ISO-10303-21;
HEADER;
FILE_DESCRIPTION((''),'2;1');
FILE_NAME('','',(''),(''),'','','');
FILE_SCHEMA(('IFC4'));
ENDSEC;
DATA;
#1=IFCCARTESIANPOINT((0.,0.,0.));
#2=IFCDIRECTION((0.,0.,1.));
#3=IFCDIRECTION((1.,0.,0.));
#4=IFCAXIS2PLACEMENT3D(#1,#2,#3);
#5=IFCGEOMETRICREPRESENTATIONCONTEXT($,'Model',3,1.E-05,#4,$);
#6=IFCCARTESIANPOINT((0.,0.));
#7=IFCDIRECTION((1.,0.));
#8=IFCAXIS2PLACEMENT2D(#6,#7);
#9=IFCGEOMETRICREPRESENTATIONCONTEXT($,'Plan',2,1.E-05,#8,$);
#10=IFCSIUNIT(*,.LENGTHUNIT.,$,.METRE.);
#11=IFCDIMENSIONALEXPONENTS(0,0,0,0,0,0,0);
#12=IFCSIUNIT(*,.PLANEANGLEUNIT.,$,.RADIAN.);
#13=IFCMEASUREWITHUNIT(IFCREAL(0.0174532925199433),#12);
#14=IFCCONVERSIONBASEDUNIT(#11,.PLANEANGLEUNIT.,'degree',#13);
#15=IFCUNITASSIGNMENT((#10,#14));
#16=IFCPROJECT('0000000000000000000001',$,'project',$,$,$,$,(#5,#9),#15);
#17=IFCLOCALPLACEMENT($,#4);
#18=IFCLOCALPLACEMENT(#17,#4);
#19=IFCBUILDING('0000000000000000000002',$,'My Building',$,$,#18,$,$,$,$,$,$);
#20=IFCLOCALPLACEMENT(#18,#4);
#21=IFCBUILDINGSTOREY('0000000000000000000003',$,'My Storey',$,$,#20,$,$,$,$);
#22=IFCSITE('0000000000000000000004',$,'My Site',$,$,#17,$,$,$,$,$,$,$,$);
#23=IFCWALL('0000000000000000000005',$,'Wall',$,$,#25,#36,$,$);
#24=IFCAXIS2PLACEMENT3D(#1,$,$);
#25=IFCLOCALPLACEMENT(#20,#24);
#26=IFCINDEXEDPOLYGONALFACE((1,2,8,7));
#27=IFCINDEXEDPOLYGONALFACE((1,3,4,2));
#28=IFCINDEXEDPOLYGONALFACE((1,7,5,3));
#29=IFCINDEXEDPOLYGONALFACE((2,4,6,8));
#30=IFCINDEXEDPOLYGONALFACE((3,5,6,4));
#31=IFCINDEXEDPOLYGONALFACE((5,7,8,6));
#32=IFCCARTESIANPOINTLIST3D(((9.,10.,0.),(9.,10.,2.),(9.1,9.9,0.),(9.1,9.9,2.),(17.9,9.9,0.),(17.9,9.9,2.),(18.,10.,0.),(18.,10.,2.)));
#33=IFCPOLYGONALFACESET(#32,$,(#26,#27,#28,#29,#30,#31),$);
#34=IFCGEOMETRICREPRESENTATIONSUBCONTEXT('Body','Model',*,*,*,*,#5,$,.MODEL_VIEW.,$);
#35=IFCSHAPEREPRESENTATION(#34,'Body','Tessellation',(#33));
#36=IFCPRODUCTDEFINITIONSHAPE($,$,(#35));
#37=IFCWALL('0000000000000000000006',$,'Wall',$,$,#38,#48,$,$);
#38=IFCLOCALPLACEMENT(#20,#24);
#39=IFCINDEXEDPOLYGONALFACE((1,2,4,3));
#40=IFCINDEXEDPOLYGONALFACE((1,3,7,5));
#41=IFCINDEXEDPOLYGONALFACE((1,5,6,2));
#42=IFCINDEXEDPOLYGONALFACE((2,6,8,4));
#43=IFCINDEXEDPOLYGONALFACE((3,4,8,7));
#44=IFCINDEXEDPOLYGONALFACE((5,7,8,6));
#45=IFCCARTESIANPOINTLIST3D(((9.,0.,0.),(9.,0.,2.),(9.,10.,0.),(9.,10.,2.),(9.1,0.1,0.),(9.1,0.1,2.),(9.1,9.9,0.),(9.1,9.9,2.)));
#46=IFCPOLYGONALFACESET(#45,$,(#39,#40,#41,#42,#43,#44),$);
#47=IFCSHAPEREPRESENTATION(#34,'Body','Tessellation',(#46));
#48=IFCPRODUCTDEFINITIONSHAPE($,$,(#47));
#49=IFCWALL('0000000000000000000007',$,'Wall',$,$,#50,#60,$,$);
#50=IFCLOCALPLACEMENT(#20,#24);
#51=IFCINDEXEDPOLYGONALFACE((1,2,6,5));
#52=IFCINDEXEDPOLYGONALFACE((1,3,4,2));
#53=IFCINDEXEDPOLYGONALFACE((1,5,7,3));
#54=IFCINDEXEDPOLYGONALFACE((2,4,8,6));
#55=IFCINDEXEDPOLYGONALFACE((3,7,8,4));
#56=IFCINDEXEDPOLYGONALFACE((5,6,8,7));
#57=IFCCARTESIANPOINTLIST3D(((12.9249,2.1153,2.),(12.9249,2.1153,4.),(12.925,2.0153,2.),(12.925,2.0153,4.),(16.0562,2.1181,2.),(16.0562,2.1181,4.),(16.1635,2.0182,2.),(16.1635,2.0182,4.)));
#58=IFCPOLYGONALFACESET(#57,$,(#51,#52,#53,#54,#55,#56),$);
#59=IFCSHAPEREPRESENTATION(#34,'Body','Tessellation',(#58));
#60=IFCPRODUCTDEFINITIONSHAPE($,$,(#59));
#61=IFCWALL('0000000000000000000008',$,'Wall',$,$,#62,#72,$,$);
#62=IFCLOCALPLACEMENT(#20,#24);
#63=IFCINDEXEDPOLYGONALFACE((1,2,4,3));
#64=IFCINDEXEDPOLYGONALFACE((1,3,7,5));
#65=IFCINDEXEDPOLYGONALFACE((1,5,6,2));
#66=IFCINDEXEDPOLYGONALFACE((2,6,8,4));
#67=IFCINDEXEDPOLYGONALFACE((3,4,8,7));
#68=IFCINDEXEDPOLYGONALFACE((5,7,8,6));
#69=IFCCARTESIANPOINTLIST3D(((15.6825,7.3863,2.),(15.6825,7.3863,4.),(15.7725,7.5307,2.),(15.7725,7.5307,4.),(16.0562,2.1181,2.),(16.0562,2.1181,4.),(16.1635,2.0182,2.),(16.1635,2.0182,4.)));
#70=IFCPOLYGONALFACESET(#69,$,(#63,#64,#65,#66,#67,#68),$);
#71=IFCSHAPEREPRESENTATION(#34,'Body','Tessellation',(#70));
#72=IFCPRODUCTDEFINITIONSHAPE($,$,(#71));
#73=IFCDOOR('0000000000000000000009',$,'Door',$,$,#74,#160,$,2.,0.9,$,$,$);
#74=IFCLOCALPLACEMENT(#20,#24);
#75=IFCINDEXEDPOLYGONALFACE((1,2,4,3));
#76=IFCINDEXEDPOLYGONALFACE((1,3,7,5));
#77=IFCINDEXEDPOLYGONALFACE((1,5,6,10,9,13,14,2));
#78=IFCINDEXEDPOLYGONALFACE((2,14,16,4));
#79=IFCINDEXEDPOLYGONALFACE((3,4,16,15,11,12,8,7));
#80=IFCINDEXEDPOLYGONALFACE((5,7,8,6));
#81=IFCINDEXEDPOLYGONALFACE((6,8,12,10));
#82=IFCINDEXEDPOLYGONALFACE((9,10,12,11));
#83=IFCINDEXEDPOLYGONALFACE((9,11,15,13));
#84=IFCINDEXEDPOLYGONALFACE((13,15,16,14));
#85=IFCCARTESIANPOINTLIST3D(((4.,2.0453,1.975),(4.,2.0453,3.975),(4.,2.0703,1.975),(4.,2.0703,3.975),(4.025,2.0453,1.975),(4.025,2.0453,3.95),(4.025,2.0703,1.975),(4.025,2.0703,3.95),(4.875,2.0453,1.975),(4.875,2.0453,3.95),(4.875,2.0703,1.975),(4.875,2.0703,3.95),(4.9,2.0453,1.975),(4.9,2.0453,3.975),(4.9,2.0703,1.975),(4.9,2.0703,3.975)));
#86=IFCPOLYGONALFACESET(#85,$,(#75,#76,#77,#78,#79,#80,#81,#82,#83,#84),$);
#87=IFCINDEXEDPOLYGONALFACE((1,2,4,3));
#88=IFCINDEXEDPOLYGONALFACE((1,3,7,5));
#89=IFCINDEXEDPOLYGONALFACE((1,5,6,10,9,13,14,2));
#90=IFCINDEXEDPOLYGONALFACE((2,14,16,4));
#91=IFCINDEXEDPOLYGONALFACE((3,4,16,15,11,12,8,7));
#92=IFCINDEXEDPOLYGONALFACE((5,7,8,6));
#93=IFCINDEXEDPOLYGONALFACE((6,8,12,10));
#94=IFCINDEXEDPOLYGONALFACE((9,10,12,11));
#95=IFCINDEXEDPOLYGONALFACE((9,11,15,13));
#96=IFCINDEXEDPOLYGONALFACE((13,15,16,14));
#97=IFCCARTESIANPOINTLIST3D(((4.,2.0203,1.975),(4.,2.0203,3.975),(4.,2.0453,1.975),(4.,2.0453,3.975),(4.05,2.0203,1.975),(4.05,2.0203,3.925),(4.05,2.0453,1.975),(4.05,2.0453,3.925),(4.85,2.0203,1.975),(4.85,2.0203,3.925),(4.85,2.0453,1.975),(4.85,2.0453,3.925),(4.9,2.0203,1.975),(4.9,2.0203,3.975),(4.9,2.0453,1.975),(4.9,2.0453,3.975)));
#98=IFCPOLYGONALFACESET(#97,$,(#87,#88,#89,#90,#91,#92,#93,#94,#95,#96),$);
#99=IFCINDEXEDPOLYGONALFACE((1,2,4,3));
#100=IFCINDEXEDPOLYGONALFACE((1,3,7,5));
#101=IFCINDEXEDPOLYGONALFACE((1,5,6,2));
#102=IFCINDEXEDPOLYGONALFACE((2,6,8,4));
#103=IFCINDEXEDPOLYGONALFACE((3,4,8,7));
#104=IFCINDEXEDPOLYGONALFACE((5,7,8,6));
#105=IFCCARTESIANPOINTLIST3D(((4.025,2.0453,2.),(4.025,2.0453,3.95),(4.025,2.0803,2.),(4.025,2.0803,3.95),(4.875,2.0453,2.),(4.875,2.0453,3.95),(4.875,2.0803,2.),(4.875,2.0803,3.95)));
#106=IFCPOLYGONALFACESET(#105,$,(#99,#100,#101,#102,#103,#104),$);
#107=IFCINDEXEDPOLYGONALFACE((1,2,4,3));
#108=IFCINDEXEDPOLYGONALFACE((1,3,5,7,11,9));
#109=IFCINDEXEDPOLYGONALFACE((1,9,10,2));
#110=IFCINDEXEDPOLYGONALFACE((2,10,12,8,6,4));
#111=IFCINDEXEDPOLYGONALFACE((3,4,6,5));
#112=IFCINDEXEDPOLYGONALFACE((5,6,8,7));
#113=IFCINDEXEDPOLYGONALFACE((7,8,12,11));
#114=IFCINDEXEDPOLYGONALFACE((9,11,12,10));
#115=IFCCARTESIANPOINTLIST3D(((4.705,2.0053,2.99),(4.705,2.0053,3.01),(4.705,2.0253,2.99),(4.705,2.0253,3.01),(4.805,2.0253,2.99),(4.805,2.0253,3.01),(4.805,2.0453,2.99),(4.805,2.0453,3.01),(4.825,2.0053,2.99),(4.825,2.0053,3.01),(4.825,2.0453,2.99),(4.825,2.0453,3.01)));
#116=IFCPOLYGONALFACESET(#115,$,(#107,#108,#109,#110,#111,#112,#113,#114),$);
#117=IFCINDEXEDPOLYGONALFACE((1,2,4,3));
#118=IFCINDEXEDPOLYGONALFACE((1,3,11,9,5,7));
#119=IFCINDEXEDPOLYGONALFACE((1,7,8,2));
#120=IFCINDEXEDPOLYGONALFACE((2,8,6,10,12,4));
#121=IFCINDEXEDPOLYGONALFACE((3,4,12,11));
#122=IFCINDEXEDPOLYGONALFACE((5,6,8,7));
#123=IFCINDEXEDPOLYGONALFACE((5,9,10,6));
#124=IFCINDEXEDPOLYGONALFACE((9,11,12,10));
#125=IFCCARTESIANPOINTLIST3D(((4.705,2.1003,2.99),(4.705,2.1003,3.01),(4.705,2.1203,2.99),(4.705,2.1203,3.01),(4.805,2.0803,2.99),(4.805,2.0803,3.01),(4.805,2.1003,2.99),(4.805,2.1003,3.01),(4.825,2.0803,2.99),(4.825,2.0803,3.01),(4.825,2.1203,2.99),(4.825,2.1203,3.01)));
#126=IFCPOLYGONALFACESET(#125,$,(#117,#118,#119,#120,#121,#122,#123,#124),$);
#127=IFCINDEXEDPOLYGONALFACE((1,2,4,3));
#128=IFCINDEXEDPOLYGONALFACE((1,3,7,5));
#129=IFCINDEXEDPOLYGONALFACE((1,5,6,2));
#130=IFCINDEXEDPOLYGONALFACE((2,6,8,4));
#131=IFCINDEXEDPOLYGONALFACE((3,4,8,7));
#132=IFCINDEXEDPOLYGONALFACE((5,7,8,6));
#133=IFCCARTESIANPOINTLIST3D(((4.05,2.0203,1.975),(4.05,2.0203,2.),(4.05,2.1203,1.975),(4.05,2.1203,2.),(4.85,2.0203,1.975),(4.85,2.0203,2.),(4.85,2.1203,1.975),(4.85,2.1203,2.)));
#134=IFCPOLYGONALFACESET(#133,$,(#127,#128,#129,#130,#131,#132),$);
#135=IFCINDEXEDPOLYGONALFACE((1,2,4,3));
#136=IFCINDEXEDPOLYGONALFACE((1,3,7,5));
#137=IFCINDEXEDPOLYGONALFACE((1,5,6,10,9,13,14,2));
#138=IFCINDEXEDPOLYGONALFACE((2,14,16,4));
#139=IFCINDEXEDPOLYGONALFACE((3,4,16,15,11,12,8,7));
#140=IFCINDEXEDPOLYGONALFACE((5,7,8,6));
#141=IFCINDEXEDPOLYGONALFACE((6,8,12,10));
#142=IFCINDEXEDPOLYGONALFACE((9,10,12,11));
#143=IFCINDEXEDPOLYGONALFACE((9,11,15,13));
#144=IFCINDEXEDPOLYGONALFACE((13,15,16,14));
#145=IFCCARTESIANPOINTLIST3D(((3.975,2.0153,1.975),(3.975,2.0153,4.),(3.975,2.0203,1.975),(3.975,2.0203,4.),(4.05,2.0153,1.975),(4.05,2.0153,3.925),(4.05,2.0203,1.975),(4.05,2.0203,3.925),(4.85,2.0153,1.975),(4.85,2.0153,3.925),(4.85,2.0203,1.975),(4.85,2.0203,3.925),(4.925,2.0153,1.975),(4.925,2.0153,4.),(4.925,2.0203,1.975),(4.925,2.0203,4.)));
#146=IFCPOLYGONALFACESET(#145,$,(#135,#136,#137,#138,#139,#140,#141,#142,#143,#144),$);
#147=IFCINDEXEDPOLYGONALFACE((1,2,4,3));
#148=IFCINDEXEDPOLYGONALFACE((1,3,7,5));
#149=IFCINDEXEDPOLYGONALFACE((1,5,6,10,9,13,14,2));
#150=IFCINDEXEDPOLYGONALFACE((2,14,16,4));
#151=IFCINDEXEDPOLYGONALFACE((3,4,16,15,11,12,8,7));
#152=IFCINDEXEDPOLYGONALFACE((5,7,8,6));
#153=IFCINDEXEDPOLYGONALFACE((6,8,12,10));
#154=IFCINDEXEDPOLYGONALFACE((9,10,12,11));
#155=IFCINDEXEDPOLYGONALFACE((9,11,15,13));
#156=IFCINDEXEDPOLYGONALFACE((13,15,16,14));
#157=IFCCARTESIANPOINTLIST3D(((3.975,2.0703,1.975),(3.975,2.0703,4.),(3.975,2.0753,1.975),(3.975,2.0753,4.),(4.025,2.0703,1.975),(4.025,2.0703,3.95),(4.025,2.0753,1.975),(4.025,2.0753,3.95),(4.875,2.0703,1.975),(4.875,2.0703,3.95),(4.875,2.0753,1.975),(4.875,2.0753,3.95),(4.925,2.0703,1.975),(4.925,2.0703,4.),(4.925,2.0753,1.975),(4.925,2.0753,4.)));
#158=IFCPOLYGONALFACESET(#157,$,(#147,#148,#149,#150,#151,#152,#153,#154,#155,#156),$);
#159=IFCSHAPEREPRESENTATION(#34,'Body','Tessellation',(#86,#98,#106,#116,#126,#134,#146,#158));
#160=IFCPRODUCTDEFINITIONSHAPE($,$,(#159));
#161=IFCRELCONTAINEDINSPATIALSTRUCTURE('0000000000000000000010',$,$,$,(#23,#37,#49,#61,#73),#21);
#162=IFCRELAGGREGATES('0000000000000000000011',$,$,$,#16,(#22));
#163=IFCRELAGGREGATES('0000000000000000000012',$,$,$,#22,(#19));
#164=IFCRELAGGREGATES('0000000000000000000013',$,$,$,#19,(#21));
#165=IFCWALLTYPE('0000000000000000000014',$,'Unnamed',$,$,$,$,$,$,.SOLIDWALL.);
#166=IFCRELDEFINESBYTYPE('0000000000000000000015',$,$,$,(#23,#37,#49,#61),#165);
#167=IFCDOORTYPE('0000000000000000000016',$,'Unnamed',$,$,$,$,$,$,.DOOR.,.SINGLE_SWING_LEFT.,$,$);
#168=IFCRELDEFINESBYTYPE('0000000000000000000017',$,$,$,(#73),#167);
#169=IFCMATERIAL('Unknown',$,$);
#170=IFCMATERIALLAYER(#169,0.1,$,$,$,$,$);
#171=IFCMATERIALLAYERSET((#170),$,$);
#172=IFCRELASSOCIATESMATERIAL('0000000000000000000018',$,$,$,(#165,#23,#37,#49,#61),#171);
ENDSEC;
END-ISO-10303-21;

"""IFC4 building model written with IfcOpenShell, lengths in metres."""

from ifc_helpers import new_model, entity, si_unit, converted_unit, frame, origin_with_axes, origin_2d_with_axis, place, context, subcontext, project, spatial, line, indexed_curve, outline, extrude, clip, halfspace, shape, source, transform, mapped, material, layer, layer_set, layer_usage, type_object, type_shapes, element, save


model = new_model("IFC4")

# Units and contexts
model_context = context("Model", 3, precision=1e-05, world=origin_with_axes())
plan_context = context("Plan", 2, precision=1e-05, world=origin_2d_with_axis())
body_context_1 = subcontext(model_context, "Body", "Model", "MODEL_VIEW")
body_context_2 = subcontext(plan_context, "Body", "Plan", "PLAN_VIEW")
ifc_project = project(units=[si_unit("LENGTHUNIT", "METRE"), converted_unit("PLANEANGLEUNIT", "degree", entity("IfcReal", 0.0174532925199433), si_unit("PLANEANGLEUNIT", "RADIAN"), dimensions=[0, 0, 0, 0, 0, 0, 0])], contexts=[model_context, plan_context])

# Site, building, storey
site_placement = place(None, origin_with_axes())
site = spatial("IfcSite", under=ifc_project, at=site_placement, Name="My Site")
building_placement = place(site_placement, origin_with_axes())
building = spatial("IfcBuilding", under=site, at=building_placement, Name="My Building")
storey_placement = place(building_placement, origin_with_axes())
storey = spatial("IfcBuildingStorey", under=building, at=storey_placement, Name="My Storey")

# Shared definitions
ifc_material = material(Name="Unknown")

# Walls
ifc_layer_1 = layer(ifc_material, 0.1)
ifc_layer_set_1 = layer_set([ifc_layer_1])
wall_type = type_object("IfcWallType", Name="Unnamed", PredefinedType="SOLIDWALL", material=ifc_layer_set_1)
ifc_layer_usage_1 = layer_usage(ifc_layer_set_1, "AXIS2", "POSITIVE", 0.0)
wall_1_placement = place(storey_placement, frame((18.0, 10.0, 0.0), z_axis=(0.0, 0.0, 1.0), x_axis=(-1.0, 0.0, 0.0)))
element("IfcWall", 1, at=wall_1_placement, inside=storey, type_object=wall_type, material=ifc_layer_usage_1, Name="Wall", context=body_context_1, shape_type="Clipping", body=[
    clip(clip(extrude(outline(indexed_curve([(0.0, 0.0), (0.0, 0.1), (9.0, 0.1), (9.0, 0.0), (0.0, 0.0)], self_intersect=False)), origin_with_axes(), (0.0, 0.0, 1.0), 2.0), halfspace(frame((9.0, 0.0, 0.0), z_axis=(0.707107, 0.707107, 0.0), x_axis=(0.707107, -0.707107, 0.0)), False)), halfspace(frame((0.0, 0.0, 0.0), z_axis=(-0.707107, 0.707107, 0.0), x_axis=(0.707107, 0.707107, 0.0)), False)),
])
ifc_layer_usage_2 = layer_usage(ifc_layer_set_1, "AXIS2", "POSITIVE", 0.0)
wall_2_placement = place(storey_placement, frame((9.0, 10.0, 0.0), z_axis=(0.0, 0.0, 1.0), x_axis=(0.0, -1.0, 0.0)))
element("IfcWall", 2, at=wall_2_placement, inside=storey, type_object=wall_type, material=ifc_layer_usage_2, Name="Wall", context=body_context_1, shape_type="Clipping", body=[
    clip(clip(extrude(outline(indexed_curve([(0.0, 0.0), (0.0, 0.1), (10.0, 0.1), (10.0, 0.0), (0.0, 0.0)], self_intersect=False)), origin_with_axes(), (0.0, 0.0, 1.0), 2.0), halfspace(frame((10.0, 0.0, 0.0), z_axis=(0.707108, 0.707105, 0.0), x_axis=(0.707105, -0.707108, 0.0)), False)), halfspace(frame((0.0, 0.0, 0.0), z_axis=(-0.707107, 0.707107, 0.0), x_axis=(0.707107, 0.707107, 0.0)), False)),
])
ifc_layer_usage_3 = layer_usage(ifc_layer_set_1, "AXIS2", "POSITIVE", 0.0)
wall_3_placement = place(storey_placement, frame((12.925, 2.0153, 2.0), z_axis=(0.0, 0.0, 1.0), x_axis=(1.0, 0.000878, 0.0)))
element("IfcWall", 3, at=wall_3_placement, inside=storey, type_object=wall_type, material=ifc_layer_usage_3, Name="Wall", context=body_context_1, shape_type="Clipping", body=[
    clip(extrude(outline(indexed_curve([(0.0, 0.0), (0.0, 0.1), (3.2385, 0.1), (3.2385, 0.0), (0.0, 0.0)], self_intersect=False)), origin_with_axes(), (0.0, 0.0, 1.0), 2.0), halfspace(frame((3.2385, 0.0, -2.0), z_axis=(0.681958, 0.731391, 0.0), x_axis=(0.731391, -0.681958, 0.0)), False)),
])
ifc_layer_usage_4 = layer_usage(ifc_layer_set_1, "AXIS2", "POSITIVE", 0.0)
wall_4_placement = place(storey_placement, frame((16.1635, 2.0182, 2.0), z_axis=(0.0, 0.0, 1.0), x_axis=(-0.070754, 0.997494, 0.0)))
element("IfcWall", 4, at=wall_4_placement, inside=storey, type_object=wall_type, material=ifc_layer_usage_4, Name="Wall", context=body_context_1, shape_type="Clipping", body=[
    clip(clip(extrude(outline(indexed_curve([(0.0, 0.0), (0.0, 0.1), (5.5264, 0.1), (5.5264, 0.0), (0.0, 0.0)], self_intersect=False)), origin_with_axes(), (0.0, 0.0, 1.0), 2.0), halfspace(frame((5.5264, 0.0, -2.0), z_axis=(0.587583, 0.809165, 0.0), x_axis=(0.809164, -0.587582, 0.0)), False)), halfspace(frame((0.0, 0.0, -2.0), z_axis=(-0.681949, 0.7314, 0.0), x_axis=(0.7314, 0.681949, 0.0)), False)),
])

# Door
door_type = type_object("IfcDoorType", Name="Unnamed", OperationType="SINGLE_SWING_LEFT", PredefinedType="DOOR")
shared_shape_1 = source(origin_with_axes(), body_context_1, "Body", "SolidModel", [
    extrude(outline(indexed_curve([(0.0, 0.0), (0.0, 2.0), (0.9, 2.0), (0.9, 0.0), (0.875, 0.0), (0.875, 1.975), (0.025, 1.975), (0.025, 0.0)], segments=[line(1, 2, 3, 4, 5, 6, 7, 8, 1)])), frame((0.0, 0.025, 0.0), z_axis=(0.0, -1.0, 0.0), x_axis=(1.0, 0.0, 0.0)), (0.0, 0.0, -1.0), 0.025),
    extrude(outline(indexed_curve([(0.0, 0.0), (0.0, 2.0), (0.9, 2.0), (0.9, 0.0), (0.85, 0.0), (0.85, 1.95), (0.05, 1.95), (0.05, 0.0)], segments=[line(1, 2, 3, 4, 5, 6, 7, 8, 1)])), frame((0.0, 0.0, 0.0), z_axis=(0.0, -1.0, 0.0), x_axis=(1.0, 0.0, 0.0)), (0.0, 0.0, -1.0), 0.025),
    extrude(outline(indexed_curve([(0.0, 0.0), (0.85, 0.0), (0.85, 0.035), (0.0, 0.035)], segments=[line(1, 2, 3, 4, 1)])), frame((0.025, 0.025, 0.025), z_axis=(0.0, 0.0, 1.0), x_axis=(1.0, 0.0, 0.0)), (0.0, 0.0, 1.0), 1.95),
    extrude(outline(indexed_curve([(0.0, 0.0), (0.0, -0.04), (-0.12, -0.04), (-0.12, -0.02), (-0.02, -0.02), (-0.02, 0.0)], segments=[line(1, 2, 3, 4, 5, 6, 1)])), frame((0.825, 0.025, 1.015), z_axis=(0.0, 0.0, 1.0), x_axis=(1.0, 0.0, 0.0)), (0.0, 0.0, 1.0), 0.02),
    extrude(outline(indexed_curve([(0.0, 0.0), (0.0, 0.04), (-0.12, 0.04), (-0.12, 0.02), (-0.02, 0.02), (-0.02, 0.0)], segments=[line(1, 2, 3, 4, 5, 6, 1)])), frame((0.825, 0.06, 1.015), z_axis=(0.0, 0.0, 1.0), x_axis=(1.0, 0.0, 0.0)), (0.0, 0.0, 1.0), 0.02),
    extrude(outline(indexed_curve([(0.0, 0.0), (0.8, 0.0), (0.8, 0.1), (0.0, 0.1)], segments=[line(1, 2, 3, 4, 1)])), frame((0.05, 0.0, 0.0), z_axis=(0.0, 0.0, 1.0), x_axis=(1.0, 0.0, 0.0)), (0.0, 0.0, 1.0), 0.025),
    extrude(outline(indexed_curve([(0.0, 0.0), (0.0, 2.025), (0.95, 2.025), (0.95, 0.0), (0.875, 0.0), (0.875, 1.95), (0.075, 1.95), (0.075, 0.0)], segments=[line(1, 2, 3, 4, 5, 6, 7, 8, 1)])), frame((-0.025, -0.005, 0.0), z_axis=(0.0, -1.0, 0.0), x_axis=(1.0, 0.0, 0.0)), (0.0, 0.0, -1.0), 0.005),
    extrude(outline(indexed_curve([(0.0, 0.0), (0.0, 2.025), (0.95, 2.025), (0.95, 0.0), (0.9, 0.0), (0.9, 1.975), (0.05, 1.975), (0.05, 0.0)], segments=[line(1, 2, 3, 4, 5, 6, 7, 8, 1)])), frame((-0.025, 0.05, 0.0), z_axis=(0.0, -1.0, 0.0), x_axis=(1.0, 0.0, 0.0)), (0.0, 0.0, -1.0), 0.005),
])
shared_shape_2 = source(origin_with_axes(), body_context_2, "Body", "Curve2D", [
    entity("IfcIndexedPolyCurve", entity("IfcCartesianPointList2D", [[0.0, 0.0], [0.0, 0.05], [0.025, 0.05], [0.025, 0.025], [0.05, 0.025], [0.05, 0.0]]), [entity("IfcLineIndex", [1, 2, 3, 4, 5, 6, 1])]),
    entity("IfcIndexedPolyCurve", entity("IfcCartesianPointList2D", [[0.9, 0.0], [0.9, 0.05], [0.875, 0.05], [0.875, 0.025], [0.85, 0.025], [0.85, 0.0]]), [entity("IfcLineIndex", [1, 2, 3, 4, 5, 6, 1])]),
    entity("IfcTrimmedCurve", entity("IfcEllipse", entity("IfcAxis2Placement2D", entity("IfcCartesianPoint", [0.06, 0.05]), entity("IfcDirection", [1.0, 0.0])), 0.815, 0.85), [entity("IfcCartesianPoint", [0.875, 0.05])], [entity("IfcCartesianPoint", [0.06, 0.9])], True, "CARTESIAN"),
    entity("IfcIndexedPolyCurve", entity("IfcCartesianPointList2D", [[0.025, 0.05], [0.06, 0.05], [0.06, 0.9], [0.025, 0.9]]), [entity("IfcLineIndex", [1, 2, 3, 4, 1])]),
])
type_shapes(door_type, [shared_shape_1, shared_shape_2])
for number, where, z_axis, x_axis, name in (
    (5, (4.0, 2.0203, 1.975), (0.0, 0.0, 1.0), (1.0, 0.0, 0.0), "Door"),
):
    element("IfcDoor", number, at=place(storey_placement, frame(where, z_axis=z_axis, x_axis=x_axis)), inside=storey, type_object=door_type, Name=name, OverallHeight=2.0, OverallWidth=0.9, shapes=[
        shape(body_context_1, "Body", "MappedRepresentation", [mapped(shared_shape_1, transform((0.0, 0.0, 0.0), x_axis=(1.0, 0.0, 0.0), y_axis=(0.0, 1.0, 0.0), z_axis=(0.0, 0.0, 1.0), scale=1.0))]),
        shape(body_context_2, "Body", "MappedRepresentation", [mapped(shared_shape_2, transform((0.0, 0.0, 0.0), x_axis=(1.0, 0.0, 0.0), y_axis=(0.0, 1.0, 0.0), z_axis=(0.0, 0.0, 1.0), scale=1.0))]),
    ])

save(model, "model.ifc")
